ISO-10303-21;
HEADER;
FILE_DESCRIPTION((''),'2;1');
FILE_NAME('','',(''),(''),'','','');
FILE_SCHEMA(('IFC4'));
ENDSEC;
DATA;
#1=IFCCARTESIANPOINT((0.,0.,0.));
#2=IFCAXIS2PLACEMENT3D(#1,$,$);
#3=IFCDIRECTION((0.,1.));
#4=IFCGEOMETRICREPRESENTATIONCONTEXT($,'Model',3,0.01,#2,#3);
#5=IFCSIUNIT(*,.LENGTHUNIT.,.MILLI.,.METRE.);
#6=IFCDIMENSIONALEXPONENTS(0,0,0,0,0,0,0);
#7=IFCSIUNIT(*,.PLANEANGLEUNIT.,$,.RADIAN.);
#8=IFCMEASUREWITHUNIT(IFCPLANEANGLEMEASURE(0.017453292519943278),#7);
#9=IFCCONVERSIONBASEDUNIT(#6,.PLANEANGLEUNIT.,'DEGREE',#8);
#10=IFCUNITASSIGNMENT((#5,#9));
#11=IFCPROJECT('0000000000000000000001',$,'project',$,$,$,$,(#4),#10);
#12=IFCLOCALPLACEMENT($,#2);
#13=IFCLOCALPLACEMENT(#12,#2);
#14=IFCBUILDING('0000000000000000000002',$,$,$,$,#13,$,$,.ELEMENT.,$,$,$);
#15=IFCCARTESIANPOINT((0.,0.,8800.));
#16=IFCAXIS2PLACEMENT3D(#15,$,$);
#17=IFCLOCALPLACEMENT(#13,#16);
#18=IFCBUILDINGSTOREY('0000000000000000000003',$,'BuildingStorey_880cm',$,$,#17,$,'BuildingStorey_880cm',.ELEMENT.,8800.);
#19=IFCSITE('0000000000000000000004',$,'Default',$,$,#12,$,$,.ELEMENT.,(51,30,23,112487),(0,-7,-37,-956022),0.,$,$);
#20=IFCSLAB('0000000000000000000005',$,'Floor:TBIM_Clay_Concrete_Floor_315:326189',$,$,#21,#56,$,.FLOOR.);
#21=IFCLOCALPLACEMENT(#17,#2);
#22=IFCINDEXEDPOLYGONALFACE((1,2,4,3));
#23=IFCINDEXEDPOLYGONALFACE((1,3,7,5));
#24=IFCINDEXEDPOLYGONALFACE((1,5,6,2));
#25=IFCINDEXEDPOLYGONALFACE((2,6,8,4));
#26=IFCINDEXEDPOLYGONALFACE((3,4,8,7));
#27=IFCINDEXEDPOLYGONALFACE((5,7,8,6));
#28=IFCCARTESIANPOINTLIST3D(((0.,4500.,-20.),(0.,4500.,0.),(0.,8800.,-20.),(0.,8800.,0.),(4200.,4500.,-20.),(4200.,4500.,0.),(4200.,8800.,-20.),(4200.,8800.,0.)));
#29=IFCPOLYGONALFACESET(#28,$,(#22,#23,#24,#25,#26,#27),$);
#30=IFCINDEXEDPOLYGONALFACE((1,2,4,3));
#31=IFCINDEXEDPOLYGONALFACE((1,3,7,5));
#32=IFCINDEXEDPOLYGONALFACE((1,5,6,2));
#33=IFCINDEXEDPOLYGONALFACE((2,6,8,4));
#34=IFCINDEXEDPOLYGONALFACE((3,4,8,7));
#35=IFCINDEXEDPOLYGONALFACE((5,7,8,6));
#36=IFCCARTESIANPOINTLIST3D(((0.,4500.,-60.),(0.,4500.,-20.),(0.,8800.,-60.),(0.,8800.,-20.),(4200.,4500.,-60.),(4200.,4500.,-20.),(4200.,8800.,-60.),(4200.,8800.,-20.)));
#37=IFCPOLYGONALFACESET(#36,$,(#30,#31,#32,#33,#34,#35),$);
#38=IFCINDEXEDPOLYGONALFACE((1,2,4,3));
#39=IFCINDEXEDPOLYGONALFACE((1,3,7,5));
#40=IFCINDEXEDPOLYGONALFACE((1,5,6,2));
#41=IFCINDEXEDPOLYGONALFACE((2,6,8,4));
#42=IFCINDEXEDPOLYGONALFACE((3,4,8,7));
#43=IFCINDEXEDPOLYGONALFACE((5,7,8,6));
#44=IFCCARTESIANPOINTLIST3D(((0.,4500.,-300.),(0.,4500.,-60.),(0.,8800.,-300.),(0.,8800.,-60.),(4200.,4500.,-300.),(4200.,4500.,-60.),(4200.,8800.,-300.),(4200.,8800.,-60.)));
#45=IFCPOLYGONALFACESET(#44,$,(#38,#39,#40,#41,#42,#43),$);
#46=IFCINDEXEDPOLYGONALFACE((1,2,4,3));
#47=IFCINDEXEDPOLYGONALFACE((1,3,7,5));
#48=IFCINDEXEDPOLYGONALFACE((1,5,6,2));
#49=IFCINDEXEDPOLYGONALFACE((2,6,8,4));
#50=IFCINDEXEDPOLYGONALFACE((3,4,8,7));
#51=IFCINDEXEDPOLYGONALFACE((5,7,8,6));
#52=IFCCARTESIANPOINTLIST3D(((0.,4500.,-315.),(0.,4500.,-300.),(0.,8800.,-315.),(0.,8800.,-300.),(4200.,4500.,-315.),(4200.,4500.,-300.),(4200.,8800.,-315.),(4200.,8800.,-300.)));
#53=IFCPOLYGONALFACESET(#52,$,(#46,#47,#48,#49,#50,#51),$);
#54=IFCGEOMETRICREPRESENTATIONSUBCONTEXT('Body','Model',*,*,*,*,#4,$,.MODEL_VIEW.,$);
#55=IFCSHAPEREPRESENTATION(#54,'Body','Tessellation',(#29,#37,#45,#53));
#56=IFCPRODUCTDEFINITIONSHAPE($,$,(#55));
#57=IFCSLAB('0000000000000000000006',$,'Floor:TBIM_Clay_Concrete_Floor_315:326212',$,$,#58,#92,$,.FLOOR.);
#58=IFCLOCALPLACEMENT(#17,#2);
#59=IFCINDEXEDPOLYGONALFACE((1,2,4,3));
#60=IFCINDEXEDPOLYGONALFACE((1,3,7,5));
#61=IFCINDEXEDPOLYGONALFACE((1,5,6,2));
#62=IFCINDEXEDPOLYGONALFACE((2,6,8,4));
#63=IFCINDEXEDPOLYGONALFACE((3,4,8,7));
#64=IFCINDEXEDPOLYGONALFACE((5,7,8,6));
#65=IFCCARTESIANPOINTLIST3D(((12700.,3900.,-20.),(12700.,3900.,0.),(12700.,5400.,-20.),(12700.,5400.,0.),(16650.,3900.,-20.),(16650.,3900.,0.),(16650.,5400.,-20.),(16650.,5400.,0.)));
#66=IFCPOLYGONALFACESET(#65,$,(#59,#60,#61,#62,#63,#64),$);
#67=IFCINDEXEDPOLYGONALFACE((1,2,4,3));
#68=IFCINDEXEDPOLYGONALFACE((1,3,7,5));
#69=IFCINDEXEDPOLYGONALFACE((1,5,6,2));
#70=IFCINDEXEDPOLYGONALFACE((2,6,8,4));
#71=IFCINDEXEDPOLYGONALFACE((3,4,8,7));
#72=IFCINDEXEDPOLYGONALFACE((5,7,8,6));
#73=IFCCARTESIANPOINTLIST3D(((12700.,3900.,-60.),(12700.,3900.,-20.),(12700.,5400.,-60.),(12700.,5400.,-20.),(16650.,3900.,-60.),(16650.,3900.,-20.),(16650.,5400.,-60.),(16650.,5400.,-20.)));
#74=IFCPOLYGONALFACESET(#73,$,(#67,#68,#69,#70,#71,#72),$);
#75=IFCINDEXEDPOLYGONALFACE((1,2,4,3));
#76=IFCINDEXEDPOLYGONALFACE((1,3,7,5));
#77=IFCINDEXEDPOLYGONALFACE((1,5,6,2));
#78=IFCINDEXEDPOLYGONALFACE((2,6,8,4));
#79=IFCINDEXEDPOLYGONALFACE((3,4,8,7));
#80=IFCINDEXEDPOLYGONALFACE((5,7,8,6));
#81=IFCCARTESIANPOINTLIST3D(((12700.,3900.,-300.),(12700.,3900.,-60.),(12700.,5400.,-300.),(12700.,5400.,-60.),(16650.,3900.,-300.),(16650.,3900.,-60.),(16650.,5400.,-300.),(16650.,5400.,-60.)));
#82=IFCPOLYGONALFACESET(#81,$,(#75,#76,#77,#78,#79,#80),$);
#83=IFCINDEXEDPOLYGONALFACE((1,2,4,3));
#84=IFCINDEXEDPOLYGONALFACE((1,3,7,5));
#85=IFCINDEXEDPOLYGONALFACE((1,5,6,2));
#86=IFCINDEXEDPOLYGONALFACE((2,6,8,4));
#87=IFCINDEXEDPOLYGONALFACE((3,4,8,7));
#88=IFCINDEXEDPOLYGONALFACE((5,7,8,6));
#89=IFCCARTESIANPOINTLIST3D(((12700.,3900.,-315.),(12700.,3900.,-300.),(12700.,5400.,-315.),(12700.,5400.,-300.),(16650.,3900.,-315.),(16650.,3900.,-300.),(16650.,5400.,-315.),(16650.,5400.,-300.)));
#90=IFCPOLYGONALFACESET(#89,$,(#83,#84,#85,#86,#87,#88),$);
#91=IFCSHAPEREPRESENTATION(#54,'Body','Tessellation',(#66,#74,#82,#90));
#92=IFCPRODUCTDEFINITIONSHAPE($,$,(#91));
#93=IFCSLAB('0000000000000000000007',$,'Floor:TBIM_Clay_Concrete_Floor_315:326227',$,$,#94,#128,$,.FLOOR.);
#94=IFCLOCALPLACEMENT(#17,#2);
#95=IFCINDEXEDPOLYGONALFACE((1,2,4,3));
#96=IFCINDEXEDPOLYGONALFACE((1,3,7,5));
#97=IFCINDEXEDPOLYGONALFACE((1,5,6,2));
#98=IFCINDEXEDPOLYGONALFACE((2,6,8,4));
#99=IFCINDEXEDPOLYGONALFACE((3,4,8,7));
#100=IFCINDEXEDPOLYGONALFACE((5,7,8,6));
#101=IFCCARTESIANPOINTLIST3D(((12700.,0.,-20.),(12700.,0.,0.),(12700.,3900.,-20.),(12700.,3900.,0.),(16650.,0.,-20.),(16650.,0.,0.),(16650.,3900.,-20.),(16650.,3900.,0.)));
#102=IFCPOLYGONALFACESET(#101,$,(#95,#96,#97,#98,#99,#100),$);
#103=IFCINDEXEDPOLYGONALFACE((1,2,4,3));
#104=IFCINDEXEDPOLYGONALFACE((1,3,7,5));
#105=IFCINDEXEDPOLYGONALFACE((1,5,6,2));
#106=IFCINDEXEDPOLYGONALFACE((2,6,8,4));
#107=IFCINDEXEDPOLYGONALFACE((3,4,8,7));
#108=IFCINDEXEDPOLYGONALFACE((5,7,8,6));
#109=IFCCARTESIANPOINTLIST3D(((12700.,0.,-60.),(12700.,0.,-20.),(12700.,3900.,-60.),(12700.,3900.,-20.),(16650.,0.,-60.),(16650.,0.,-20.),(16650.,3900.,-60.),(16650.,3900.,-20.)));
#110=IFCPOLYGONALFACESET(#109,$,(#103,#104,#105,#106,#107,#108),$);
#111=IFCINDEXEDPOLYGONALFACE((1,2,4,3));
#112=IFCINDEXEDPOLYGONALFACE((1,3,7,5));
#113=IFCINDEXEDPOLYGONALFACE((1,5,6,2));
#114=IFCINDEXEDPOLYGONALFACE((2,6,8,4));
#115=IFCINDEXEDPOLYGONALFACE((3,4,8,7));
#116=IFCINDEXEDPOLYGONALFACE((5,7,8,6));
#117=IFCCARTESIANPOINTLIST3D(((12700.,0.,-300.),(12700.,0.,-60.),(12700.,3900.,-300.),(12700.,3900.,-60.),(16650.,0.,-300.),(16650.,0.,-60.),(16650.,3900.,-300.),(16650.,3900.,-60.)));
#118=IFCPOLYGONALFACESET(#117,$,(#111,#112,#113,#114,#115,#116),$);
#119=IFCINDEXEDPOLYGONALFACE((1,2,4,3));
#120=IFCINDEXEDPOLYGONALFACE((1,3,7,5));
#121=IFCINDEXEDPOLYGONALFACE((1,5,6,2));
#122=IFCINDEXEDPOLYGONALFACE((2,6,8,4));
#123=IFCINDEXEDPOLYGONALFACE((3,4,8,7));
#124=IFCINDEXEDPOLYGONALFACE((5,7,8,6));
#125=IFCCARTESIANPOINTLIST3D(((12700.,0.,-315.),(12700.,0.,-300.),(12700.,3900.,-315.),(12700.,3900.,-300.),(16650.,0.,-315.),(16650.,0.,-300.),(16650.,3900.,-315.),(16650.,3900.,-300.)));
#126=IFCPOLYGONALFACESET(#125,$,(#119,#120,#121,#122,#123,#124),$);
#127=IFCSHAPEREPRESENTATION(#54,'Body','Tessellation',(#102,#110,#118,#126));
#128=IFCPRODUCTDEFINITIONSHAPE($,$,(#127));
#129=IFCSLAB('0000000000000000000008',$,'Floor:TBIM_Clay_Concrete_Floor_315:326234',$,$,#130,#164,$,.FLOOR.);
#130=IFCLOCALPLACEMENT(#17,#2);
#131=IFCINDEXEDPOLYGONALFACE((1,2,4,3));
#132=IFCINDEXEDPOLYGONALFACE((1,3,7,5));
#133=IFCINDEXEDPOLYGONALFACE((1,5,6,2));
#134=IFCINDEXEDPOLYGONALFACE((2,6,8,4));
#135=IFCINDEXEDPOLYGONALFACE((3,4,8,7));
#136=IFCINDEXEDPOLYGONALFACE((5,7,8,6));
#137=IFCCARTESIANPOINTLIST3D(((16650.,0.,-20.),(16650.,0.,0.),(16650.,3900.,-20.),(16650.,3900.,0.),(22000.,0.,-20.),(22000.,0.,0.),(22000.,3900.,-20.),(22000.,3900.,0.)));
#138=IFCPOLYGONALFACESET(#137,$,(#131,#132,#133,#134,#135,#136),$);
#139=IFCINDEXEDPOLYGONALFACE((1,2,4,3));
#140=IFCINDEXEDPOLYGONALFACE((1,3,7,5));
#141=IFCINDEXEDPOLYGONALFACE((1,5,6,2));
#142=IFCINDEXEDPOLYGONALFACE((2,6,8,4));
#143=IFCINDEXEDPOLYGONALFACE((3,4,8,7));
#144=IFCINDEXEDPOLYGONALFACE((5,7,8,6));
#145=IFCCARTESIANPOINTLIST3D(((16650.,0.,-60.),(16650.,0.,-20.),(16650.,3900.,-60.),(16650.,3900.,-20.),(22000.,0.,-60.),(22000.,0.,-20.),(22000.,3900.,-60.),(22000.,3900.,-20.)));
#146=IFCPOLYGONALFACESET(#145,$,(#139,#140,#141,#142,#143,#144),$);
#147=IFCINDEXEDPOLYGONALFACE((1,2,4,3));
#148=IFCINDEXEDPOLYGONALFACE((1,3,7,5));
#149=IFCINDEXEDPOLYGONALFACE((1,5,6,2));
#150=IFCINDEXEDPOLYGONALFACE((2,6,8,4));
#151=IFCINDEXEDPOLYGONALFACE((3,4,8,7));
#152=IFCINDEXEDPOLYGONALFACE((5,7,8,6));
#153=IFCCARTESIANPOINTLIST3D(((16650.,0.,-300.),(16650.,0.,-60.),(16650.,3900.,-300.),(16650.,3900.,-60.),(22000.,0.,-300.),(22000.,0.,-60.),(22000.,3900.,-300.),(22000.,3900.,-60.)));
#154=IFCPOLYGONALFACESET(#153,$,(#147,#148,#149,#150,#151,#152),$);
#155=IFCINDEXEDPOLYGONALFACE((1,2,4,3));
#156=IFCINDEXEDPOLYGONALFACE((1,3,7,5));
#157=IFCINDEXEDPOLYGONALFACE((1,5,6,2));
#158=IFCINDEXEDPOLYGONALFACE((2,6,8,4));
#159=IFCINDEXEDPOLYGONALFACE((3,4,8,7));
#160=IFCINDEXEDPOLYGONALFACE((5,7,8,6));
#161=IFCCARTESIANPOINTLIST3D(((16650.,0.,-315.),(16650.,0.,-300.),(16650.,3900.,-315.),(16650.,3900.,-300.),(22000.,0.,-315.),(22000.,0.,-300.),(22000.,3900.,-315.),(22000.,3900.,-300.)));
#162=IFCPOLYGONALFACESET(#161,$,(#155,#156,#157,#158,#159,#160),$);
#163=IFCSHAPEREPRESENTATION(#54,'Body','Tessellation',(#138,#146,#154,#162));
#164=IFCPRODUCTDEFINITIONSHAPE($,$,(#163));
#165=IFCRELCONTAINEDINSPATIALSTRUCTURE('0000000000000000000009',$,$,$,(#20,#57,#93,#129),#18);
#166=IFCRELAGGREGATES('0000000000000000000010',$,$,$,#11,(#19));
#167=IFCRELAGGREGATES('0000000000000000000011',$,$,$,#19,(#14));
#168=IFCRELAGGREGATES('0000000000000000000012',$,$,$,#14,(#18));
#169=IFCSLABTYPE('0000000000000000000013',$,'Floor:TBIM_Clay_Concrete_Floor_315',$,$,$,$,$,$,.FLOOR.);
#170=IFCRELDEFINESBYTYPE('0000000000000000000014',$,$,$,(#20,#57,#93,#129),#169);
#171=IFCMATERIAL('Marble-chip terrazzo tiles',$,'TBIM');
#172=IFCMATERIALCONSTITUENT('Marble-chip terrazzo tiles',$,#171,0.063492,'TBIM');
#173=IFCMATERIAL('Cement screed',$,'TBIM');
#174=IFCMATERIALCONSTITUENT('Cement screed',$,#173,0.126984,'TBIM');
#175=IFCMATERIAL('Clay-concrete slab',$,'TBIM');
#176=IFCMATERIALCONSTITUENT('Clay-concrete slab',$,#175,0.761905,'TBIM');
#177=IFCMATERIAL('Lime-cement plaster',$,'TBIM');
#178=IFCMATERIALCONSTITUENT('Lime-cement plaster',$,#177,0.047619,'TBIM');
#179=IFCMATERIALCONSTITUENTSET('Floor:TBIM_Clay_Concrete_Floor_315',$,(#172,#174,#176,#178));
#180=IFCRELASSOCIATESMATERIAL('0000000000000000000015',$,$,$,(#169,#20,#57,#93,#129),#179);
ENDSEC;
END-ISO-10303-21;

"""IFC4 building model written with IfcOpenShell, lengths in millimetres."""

from ifc_helpers import new_model, entity, si_unit, converted_unit, direction, frame, origin, place, context, subcontext, project, spatial, indexed_curve, outline, extrude, material, constituent, constituent_set, type_object, element, save


model = new_model("IFC4")

# Units and contexts
model_context = context("Model", 3, precision=0.01, world=origin(), true_north=direction((0.0, 1.0)))
body_context = subcontext(model_context, "Body", "Model", "MODEL_VIEW")
ifc_project = project(units=[si_unit("LENGTHUNIT", "METRE", prefix="MILLI"), converted_unit("PLANEANGLEUNIT", "DEGREE", entity("IfcPlaneAngleMeasure", 0.017453292519943278), si_unit("PLANEANGLEUNIT", "RADIAN"), dimensions=[0, 0, 0, 0, 0, 0, 0])], contexts=[model_context])

# Site, building, storey
site_placement = place(None, origin())
site = spatial("IfcSite", under=ifc_project, at=site_placement, Name="Default", CompositionType="ELEMENT", RefLatitude=(51, 30, 23, 112487), RefLongitude=(0, -7, -37, -956022), RefElevation=0.0)
building_placement = place(site_placement, origin())
building = spatial("IfcBuilding", under=site, at=building_placement, CompositionType="ELEMENT")
storey_placement = place(building_placement, frame((0.0, 0.0, 8800.0)))
storey = spatial("IfcBuildingStorey", under=building, at=storey_placement, Name="BuildingStorey_880cm", LongName="BuildingStorey_880cm", CompositionType="ELEMENT", Elevation=8800.0)

# Slabs
ifc_material_1 = material(Name="Marble-chip terrazzo tiles", Category="TBIM")
ifc_constituent_1 = constituent(ifc_material_1, Name="Marble-chip terrazzo tiles", Category="TBIM", fraction=0.063492)
ifc_material_2 = material(Name="Cement screed", Category="TBIM")
ifc_constituent_2 = constituent(ifc_material_2, Name="Cement screed", Category="TBIM", fraction=0.126984)
ifc_material_3 = material(Name="Clay-concrete slab", Category="TBIM")
ifc_constituent_3 = constituent(ifc_material_3, Name="Clay-concrete slab", Category="TBIM", fraction=0.761905)
ifc_material_4 = material(Name="Lime-cement plaster", Category="TBIM")
ifc_constituent_4 = constituent(ifc_material_4, Name="Lime-cement plaster", Category="TBIM", fraction=0.047619)
ifc_constituent_set_1 = constituent_set(constituents=[ifc_constituent_1, ifc_constituent_2, ifc_constituent_3, ifc_constituent_4], Name="Floor:TBIM_Clay_Concrete_Floor_315")
slab_type = type_object("IfcSlabType", Name="Floor:TBIM_Clay_Concrete_Floor_315", PredefinedType="FLOOR", material=ifc_constituent_set_1)
slab_1_placement = place(storey_placement, origin())
element("IfcSlab", 1, at=slab_1_placement, inside=storey, type_object=slab_type, material=ifc_constituent_set_1, Name="Floor:TBIM_Clay_Concrete_Floor_315:326189", PredefinedType="FLOOR", context=body_context, shape_type="SweptSolid", body=[
    extrude(outline(indexed_curve([(-2100.0, -2150.0), (2100.0, -2150.0), (2100.0, 2150.0), (-2100.0, 2150.0), (-2100.0, -2150.0)], self_intersect=False)), frame((2100.0, 6650.0, -20.0), z_axis=(0.0, 0.0, 1.0), x_axis=(-1.0, 0.0, 0.0)), (0.0, 0.0, 1.0), 20.0),
    extrude(outline(indexed_curve([(-2100.0, -2150.0), (2100.0, -2150.0), (2100.0, 2150.0), (-2100.0, 2150.0), (-2100.0, -2150.0)], self_intersect=False)), frame((2100.0, 6650.0, -60.0), z_axis=(0.0, 0.0, 1.0), x_axis=(-1.0, 0.0, 0.0)), (0.0, 0.0, 1.0), 40.0),
    extrude(outline(indexed_curve([(-2100.0, -2150.0), (2100.0, -2150.0), (2100.0, 2150.0), (-2100.0, 2150.0), (-2100.0, -2150.0)], self_intersect=False)), frame((2100.0, 6650.0, -300.0), z_axis=(0.0, 0.0, 1.0), x_axis=(-1.0, 0.0, 0.0)), (0.0, 0.0, 1.0), 240.0),
    extrude(outline(indexed_curve([(-2100.0, -2150.0), (2100.0, -2150.0), (2100.0, 2150.0), (-2100.0, 2150.0), (-2100.0, -2150.0)], self_intersect=False)), frame((2100.0, 6650.0, -315.0), z_axis=(0.0, 0.0, 1.0), x_axis=(-1.0, 0.0, 0.0)), (0.0, 0.0, 1.0), 15.0),
])
slab_2_placement = place(storey_placement, origin())
element("IfcSlab", 2, at=slab_2_placement, inside=storey, type_object=slab_type, material=ifc_constituent_set_1, Name="Floor:TBIM_Clay_Concrete_Floor_315:326212", PredefinedType="FLOOR", context=body_context, shape_type="SweptSolid", body=[
    extrude(outline(indexed_curve([(-750.0, -1975.0), (750.0, -1975.0), (750.0, 1975.0), (-750.0, 1975.0), (-750.0, -1975.0)], self_intersect=False)), frame((14675.0, 4650.0, -20.0), z_axis=(0.0, 0.0, 1.0), x_axis=(0.0, 1.0, 0.0)), (0.0, 0.0, 1.0), 20.0),
    extrude(outline(indexed_curve([(-750.0, -1975.0), (750.0, -1975.0), (750.0, 1975.0), (-750.0, 1975.0), (-750.0, -1975.0)], self_intersect=False)), frame((14675.0, 4650.0, -60.0), z_axis=(0.0, 0.0, 1.0), x_axis=(0.0, 1.0, 0.0)), (0.0, 0.0, 1.0), 40.0),
    extrude(outline(indexed_curve([(-750.0, -1975.0), (750.0, -1975.0), (750.0, 1975.0), (-750.0, 1975.0), (-750.0, -1975.0)], self_intersect=False)), frame((14675.0, 4650.0, -300.0), z_axis=(0.0, 0.0, 1.0), x_axis=(0.0, 1.0, 0.0)), (0.0, 0.0, 1.0), 240.0),
    extrude(outline(indexed_curve([(-750.0, -1975.0), (750.0, -1975.0), (750.0, 1975.0), (-750.0, 1975.0), (-750.0, -1975.0)], self_intersect=False)), frame((14675.0, 4650.0, -315.0), z_axis=(0.0, 0.0, 1.0), x_axis=(0.0, 1.0, 0.0)), (0.0, 0.0, 1.0), 15.0),
])
slab_3_placement = place(storey_placement, origin())
element("IfcSlab", 3, at=slab_3_placement, inside=storey, type_object=slab_type, material=ifc_constituent_set_1, Name="Floor:TBIM_Clay_Concrete_Floor_315:326227", PredefinedType="FLOOR", context=body_context, shape_type="SweptSolid", body=[
    extrude(outline(indexed_curve([(-1975.0, -1950.0), (1975.0, -1950.0), (1975.0, 1950.0), (-1975.0, 1950.0), (-1975.0, -1950.0)], self_intersect=False)), frame((14675.0, 1950.0, -20.0), z_axis=(0.0, 0.0, 1.0), x_axis=(-1.0, 0.0, 0.0)), (0.0, 0.0, 1.0), 20.0),
    extrude(outline(indexed_curve([(-1975.0, -1950.0), (1975.0, -1950.0), (1975.0, 1950.0), (-1975.0, 1950.0), (-1975.0, -1950.0)], self_intersect=False)), frame((14675.0, 1950.0, -60.0), z_axis=(0.0, 0.0, 1.0), x_axis=(-1.0, 0.0, 0.0)), (0.0, 0.0, 1.0), 40.0),
    extrude(outline(indexed_curve([(-1975.0, -1950.0), (1975.0, -1950.0), (1975.0, 1950.0), (-1975.0, 1950.0), (-1975.0, -1950.0)], self_intersect=False)), frame((14675.0, 1950.0, -300.0), z_axis=(0.0, 0.0, 1.0), x_axis=(-1.0, 0.0, 0.0)), (0.0, 0.0, 1.0), 240.0),
    extrude(outline(indexed_curve([(-1975.0, -1950.0), (1975.0, -1950.0), (1975.0, 1950.0), (-1975.0, 1950.0), (-1975.0, -1950.0)], self_intersect=False)), frame((14675.0, 1950.0, -315.0), z_axis=(0.0, 0.0, 1.0), x_axis=(-1.0, 0.0, 0.0)), (0.0, 0.0, 1.0), 15.0),
])
slab_4_placement = place(storey_placement, origin())
element("IfcSlab", 4, at=slab_4_placement, inside=storey, type_object=slab_type, material=ifc_constituent_set_1, Name="Floor:TBIM_Clay_Concrete_Floor_315:326234", PredefinedType="FLOOR", context=body_context, shape_type="SweptSolid", body=[
    extrude(outline(indexed_curve([(-2675.0, -1950.0), (2675.0, -1950.0), (2675.0, 1950.0), (-2675.0, 1950.0), (-2675.0, -1950.0)], self_intersect=False)), frame((19325.0, 1950.0, -20.0), z_axis=(0.0, 0.0, 1.0), x_axis=(-1.0, 0.0, 0.0)), (0.0, 0.0, 1.0), 20.0),
    extrude(outline(indexed_curve([(-2675.0, -1950.0), (2675.0, -1950.0), (2675.0, 1950.0), (-2675.0, 1950.0), (-2675.0, -1950.0)], self_intersect=False)), frame((19325.0, 1950.0, -60.0), z_axis=(0.0, 0.0, 1.0), x_axis=(-1.0, 0.0, 0.0)), (0.0, 0.0, 1.0), 40.0),
    extrude(outline(indexed_curve([(-2675.0, -1950.0), (2675.0, -1950.0), (2675.0, 1950.0), (-2675.0, 1950.0), (-2675.0, -1950.0)], self_intersect=False)), frame((19325.0, 1950.0, -300.0), z_axis=(0.0, 0.0, 1.0), x_axis=(-1.0, 0.0, 0.0)), (0.0, 0.0, 1.0), 240.0),
    extrude(outline(indexed_curve([(-2675.0, -1950.0), (2675.0, -1950.0), (2675.0, 1950.0), (-2675.0, 1950.0), (-2675.0, -1950.0)], self_intersect=False)), frame((19325.0, 1950.0, -315.0), z_axis=(0.0, 0.0, 1.0), x_axis=(-1.0, 0.0, 0.0)), (0.0, 0.0, 1.0), 15.0),
])

save(model, "model.ifc")
